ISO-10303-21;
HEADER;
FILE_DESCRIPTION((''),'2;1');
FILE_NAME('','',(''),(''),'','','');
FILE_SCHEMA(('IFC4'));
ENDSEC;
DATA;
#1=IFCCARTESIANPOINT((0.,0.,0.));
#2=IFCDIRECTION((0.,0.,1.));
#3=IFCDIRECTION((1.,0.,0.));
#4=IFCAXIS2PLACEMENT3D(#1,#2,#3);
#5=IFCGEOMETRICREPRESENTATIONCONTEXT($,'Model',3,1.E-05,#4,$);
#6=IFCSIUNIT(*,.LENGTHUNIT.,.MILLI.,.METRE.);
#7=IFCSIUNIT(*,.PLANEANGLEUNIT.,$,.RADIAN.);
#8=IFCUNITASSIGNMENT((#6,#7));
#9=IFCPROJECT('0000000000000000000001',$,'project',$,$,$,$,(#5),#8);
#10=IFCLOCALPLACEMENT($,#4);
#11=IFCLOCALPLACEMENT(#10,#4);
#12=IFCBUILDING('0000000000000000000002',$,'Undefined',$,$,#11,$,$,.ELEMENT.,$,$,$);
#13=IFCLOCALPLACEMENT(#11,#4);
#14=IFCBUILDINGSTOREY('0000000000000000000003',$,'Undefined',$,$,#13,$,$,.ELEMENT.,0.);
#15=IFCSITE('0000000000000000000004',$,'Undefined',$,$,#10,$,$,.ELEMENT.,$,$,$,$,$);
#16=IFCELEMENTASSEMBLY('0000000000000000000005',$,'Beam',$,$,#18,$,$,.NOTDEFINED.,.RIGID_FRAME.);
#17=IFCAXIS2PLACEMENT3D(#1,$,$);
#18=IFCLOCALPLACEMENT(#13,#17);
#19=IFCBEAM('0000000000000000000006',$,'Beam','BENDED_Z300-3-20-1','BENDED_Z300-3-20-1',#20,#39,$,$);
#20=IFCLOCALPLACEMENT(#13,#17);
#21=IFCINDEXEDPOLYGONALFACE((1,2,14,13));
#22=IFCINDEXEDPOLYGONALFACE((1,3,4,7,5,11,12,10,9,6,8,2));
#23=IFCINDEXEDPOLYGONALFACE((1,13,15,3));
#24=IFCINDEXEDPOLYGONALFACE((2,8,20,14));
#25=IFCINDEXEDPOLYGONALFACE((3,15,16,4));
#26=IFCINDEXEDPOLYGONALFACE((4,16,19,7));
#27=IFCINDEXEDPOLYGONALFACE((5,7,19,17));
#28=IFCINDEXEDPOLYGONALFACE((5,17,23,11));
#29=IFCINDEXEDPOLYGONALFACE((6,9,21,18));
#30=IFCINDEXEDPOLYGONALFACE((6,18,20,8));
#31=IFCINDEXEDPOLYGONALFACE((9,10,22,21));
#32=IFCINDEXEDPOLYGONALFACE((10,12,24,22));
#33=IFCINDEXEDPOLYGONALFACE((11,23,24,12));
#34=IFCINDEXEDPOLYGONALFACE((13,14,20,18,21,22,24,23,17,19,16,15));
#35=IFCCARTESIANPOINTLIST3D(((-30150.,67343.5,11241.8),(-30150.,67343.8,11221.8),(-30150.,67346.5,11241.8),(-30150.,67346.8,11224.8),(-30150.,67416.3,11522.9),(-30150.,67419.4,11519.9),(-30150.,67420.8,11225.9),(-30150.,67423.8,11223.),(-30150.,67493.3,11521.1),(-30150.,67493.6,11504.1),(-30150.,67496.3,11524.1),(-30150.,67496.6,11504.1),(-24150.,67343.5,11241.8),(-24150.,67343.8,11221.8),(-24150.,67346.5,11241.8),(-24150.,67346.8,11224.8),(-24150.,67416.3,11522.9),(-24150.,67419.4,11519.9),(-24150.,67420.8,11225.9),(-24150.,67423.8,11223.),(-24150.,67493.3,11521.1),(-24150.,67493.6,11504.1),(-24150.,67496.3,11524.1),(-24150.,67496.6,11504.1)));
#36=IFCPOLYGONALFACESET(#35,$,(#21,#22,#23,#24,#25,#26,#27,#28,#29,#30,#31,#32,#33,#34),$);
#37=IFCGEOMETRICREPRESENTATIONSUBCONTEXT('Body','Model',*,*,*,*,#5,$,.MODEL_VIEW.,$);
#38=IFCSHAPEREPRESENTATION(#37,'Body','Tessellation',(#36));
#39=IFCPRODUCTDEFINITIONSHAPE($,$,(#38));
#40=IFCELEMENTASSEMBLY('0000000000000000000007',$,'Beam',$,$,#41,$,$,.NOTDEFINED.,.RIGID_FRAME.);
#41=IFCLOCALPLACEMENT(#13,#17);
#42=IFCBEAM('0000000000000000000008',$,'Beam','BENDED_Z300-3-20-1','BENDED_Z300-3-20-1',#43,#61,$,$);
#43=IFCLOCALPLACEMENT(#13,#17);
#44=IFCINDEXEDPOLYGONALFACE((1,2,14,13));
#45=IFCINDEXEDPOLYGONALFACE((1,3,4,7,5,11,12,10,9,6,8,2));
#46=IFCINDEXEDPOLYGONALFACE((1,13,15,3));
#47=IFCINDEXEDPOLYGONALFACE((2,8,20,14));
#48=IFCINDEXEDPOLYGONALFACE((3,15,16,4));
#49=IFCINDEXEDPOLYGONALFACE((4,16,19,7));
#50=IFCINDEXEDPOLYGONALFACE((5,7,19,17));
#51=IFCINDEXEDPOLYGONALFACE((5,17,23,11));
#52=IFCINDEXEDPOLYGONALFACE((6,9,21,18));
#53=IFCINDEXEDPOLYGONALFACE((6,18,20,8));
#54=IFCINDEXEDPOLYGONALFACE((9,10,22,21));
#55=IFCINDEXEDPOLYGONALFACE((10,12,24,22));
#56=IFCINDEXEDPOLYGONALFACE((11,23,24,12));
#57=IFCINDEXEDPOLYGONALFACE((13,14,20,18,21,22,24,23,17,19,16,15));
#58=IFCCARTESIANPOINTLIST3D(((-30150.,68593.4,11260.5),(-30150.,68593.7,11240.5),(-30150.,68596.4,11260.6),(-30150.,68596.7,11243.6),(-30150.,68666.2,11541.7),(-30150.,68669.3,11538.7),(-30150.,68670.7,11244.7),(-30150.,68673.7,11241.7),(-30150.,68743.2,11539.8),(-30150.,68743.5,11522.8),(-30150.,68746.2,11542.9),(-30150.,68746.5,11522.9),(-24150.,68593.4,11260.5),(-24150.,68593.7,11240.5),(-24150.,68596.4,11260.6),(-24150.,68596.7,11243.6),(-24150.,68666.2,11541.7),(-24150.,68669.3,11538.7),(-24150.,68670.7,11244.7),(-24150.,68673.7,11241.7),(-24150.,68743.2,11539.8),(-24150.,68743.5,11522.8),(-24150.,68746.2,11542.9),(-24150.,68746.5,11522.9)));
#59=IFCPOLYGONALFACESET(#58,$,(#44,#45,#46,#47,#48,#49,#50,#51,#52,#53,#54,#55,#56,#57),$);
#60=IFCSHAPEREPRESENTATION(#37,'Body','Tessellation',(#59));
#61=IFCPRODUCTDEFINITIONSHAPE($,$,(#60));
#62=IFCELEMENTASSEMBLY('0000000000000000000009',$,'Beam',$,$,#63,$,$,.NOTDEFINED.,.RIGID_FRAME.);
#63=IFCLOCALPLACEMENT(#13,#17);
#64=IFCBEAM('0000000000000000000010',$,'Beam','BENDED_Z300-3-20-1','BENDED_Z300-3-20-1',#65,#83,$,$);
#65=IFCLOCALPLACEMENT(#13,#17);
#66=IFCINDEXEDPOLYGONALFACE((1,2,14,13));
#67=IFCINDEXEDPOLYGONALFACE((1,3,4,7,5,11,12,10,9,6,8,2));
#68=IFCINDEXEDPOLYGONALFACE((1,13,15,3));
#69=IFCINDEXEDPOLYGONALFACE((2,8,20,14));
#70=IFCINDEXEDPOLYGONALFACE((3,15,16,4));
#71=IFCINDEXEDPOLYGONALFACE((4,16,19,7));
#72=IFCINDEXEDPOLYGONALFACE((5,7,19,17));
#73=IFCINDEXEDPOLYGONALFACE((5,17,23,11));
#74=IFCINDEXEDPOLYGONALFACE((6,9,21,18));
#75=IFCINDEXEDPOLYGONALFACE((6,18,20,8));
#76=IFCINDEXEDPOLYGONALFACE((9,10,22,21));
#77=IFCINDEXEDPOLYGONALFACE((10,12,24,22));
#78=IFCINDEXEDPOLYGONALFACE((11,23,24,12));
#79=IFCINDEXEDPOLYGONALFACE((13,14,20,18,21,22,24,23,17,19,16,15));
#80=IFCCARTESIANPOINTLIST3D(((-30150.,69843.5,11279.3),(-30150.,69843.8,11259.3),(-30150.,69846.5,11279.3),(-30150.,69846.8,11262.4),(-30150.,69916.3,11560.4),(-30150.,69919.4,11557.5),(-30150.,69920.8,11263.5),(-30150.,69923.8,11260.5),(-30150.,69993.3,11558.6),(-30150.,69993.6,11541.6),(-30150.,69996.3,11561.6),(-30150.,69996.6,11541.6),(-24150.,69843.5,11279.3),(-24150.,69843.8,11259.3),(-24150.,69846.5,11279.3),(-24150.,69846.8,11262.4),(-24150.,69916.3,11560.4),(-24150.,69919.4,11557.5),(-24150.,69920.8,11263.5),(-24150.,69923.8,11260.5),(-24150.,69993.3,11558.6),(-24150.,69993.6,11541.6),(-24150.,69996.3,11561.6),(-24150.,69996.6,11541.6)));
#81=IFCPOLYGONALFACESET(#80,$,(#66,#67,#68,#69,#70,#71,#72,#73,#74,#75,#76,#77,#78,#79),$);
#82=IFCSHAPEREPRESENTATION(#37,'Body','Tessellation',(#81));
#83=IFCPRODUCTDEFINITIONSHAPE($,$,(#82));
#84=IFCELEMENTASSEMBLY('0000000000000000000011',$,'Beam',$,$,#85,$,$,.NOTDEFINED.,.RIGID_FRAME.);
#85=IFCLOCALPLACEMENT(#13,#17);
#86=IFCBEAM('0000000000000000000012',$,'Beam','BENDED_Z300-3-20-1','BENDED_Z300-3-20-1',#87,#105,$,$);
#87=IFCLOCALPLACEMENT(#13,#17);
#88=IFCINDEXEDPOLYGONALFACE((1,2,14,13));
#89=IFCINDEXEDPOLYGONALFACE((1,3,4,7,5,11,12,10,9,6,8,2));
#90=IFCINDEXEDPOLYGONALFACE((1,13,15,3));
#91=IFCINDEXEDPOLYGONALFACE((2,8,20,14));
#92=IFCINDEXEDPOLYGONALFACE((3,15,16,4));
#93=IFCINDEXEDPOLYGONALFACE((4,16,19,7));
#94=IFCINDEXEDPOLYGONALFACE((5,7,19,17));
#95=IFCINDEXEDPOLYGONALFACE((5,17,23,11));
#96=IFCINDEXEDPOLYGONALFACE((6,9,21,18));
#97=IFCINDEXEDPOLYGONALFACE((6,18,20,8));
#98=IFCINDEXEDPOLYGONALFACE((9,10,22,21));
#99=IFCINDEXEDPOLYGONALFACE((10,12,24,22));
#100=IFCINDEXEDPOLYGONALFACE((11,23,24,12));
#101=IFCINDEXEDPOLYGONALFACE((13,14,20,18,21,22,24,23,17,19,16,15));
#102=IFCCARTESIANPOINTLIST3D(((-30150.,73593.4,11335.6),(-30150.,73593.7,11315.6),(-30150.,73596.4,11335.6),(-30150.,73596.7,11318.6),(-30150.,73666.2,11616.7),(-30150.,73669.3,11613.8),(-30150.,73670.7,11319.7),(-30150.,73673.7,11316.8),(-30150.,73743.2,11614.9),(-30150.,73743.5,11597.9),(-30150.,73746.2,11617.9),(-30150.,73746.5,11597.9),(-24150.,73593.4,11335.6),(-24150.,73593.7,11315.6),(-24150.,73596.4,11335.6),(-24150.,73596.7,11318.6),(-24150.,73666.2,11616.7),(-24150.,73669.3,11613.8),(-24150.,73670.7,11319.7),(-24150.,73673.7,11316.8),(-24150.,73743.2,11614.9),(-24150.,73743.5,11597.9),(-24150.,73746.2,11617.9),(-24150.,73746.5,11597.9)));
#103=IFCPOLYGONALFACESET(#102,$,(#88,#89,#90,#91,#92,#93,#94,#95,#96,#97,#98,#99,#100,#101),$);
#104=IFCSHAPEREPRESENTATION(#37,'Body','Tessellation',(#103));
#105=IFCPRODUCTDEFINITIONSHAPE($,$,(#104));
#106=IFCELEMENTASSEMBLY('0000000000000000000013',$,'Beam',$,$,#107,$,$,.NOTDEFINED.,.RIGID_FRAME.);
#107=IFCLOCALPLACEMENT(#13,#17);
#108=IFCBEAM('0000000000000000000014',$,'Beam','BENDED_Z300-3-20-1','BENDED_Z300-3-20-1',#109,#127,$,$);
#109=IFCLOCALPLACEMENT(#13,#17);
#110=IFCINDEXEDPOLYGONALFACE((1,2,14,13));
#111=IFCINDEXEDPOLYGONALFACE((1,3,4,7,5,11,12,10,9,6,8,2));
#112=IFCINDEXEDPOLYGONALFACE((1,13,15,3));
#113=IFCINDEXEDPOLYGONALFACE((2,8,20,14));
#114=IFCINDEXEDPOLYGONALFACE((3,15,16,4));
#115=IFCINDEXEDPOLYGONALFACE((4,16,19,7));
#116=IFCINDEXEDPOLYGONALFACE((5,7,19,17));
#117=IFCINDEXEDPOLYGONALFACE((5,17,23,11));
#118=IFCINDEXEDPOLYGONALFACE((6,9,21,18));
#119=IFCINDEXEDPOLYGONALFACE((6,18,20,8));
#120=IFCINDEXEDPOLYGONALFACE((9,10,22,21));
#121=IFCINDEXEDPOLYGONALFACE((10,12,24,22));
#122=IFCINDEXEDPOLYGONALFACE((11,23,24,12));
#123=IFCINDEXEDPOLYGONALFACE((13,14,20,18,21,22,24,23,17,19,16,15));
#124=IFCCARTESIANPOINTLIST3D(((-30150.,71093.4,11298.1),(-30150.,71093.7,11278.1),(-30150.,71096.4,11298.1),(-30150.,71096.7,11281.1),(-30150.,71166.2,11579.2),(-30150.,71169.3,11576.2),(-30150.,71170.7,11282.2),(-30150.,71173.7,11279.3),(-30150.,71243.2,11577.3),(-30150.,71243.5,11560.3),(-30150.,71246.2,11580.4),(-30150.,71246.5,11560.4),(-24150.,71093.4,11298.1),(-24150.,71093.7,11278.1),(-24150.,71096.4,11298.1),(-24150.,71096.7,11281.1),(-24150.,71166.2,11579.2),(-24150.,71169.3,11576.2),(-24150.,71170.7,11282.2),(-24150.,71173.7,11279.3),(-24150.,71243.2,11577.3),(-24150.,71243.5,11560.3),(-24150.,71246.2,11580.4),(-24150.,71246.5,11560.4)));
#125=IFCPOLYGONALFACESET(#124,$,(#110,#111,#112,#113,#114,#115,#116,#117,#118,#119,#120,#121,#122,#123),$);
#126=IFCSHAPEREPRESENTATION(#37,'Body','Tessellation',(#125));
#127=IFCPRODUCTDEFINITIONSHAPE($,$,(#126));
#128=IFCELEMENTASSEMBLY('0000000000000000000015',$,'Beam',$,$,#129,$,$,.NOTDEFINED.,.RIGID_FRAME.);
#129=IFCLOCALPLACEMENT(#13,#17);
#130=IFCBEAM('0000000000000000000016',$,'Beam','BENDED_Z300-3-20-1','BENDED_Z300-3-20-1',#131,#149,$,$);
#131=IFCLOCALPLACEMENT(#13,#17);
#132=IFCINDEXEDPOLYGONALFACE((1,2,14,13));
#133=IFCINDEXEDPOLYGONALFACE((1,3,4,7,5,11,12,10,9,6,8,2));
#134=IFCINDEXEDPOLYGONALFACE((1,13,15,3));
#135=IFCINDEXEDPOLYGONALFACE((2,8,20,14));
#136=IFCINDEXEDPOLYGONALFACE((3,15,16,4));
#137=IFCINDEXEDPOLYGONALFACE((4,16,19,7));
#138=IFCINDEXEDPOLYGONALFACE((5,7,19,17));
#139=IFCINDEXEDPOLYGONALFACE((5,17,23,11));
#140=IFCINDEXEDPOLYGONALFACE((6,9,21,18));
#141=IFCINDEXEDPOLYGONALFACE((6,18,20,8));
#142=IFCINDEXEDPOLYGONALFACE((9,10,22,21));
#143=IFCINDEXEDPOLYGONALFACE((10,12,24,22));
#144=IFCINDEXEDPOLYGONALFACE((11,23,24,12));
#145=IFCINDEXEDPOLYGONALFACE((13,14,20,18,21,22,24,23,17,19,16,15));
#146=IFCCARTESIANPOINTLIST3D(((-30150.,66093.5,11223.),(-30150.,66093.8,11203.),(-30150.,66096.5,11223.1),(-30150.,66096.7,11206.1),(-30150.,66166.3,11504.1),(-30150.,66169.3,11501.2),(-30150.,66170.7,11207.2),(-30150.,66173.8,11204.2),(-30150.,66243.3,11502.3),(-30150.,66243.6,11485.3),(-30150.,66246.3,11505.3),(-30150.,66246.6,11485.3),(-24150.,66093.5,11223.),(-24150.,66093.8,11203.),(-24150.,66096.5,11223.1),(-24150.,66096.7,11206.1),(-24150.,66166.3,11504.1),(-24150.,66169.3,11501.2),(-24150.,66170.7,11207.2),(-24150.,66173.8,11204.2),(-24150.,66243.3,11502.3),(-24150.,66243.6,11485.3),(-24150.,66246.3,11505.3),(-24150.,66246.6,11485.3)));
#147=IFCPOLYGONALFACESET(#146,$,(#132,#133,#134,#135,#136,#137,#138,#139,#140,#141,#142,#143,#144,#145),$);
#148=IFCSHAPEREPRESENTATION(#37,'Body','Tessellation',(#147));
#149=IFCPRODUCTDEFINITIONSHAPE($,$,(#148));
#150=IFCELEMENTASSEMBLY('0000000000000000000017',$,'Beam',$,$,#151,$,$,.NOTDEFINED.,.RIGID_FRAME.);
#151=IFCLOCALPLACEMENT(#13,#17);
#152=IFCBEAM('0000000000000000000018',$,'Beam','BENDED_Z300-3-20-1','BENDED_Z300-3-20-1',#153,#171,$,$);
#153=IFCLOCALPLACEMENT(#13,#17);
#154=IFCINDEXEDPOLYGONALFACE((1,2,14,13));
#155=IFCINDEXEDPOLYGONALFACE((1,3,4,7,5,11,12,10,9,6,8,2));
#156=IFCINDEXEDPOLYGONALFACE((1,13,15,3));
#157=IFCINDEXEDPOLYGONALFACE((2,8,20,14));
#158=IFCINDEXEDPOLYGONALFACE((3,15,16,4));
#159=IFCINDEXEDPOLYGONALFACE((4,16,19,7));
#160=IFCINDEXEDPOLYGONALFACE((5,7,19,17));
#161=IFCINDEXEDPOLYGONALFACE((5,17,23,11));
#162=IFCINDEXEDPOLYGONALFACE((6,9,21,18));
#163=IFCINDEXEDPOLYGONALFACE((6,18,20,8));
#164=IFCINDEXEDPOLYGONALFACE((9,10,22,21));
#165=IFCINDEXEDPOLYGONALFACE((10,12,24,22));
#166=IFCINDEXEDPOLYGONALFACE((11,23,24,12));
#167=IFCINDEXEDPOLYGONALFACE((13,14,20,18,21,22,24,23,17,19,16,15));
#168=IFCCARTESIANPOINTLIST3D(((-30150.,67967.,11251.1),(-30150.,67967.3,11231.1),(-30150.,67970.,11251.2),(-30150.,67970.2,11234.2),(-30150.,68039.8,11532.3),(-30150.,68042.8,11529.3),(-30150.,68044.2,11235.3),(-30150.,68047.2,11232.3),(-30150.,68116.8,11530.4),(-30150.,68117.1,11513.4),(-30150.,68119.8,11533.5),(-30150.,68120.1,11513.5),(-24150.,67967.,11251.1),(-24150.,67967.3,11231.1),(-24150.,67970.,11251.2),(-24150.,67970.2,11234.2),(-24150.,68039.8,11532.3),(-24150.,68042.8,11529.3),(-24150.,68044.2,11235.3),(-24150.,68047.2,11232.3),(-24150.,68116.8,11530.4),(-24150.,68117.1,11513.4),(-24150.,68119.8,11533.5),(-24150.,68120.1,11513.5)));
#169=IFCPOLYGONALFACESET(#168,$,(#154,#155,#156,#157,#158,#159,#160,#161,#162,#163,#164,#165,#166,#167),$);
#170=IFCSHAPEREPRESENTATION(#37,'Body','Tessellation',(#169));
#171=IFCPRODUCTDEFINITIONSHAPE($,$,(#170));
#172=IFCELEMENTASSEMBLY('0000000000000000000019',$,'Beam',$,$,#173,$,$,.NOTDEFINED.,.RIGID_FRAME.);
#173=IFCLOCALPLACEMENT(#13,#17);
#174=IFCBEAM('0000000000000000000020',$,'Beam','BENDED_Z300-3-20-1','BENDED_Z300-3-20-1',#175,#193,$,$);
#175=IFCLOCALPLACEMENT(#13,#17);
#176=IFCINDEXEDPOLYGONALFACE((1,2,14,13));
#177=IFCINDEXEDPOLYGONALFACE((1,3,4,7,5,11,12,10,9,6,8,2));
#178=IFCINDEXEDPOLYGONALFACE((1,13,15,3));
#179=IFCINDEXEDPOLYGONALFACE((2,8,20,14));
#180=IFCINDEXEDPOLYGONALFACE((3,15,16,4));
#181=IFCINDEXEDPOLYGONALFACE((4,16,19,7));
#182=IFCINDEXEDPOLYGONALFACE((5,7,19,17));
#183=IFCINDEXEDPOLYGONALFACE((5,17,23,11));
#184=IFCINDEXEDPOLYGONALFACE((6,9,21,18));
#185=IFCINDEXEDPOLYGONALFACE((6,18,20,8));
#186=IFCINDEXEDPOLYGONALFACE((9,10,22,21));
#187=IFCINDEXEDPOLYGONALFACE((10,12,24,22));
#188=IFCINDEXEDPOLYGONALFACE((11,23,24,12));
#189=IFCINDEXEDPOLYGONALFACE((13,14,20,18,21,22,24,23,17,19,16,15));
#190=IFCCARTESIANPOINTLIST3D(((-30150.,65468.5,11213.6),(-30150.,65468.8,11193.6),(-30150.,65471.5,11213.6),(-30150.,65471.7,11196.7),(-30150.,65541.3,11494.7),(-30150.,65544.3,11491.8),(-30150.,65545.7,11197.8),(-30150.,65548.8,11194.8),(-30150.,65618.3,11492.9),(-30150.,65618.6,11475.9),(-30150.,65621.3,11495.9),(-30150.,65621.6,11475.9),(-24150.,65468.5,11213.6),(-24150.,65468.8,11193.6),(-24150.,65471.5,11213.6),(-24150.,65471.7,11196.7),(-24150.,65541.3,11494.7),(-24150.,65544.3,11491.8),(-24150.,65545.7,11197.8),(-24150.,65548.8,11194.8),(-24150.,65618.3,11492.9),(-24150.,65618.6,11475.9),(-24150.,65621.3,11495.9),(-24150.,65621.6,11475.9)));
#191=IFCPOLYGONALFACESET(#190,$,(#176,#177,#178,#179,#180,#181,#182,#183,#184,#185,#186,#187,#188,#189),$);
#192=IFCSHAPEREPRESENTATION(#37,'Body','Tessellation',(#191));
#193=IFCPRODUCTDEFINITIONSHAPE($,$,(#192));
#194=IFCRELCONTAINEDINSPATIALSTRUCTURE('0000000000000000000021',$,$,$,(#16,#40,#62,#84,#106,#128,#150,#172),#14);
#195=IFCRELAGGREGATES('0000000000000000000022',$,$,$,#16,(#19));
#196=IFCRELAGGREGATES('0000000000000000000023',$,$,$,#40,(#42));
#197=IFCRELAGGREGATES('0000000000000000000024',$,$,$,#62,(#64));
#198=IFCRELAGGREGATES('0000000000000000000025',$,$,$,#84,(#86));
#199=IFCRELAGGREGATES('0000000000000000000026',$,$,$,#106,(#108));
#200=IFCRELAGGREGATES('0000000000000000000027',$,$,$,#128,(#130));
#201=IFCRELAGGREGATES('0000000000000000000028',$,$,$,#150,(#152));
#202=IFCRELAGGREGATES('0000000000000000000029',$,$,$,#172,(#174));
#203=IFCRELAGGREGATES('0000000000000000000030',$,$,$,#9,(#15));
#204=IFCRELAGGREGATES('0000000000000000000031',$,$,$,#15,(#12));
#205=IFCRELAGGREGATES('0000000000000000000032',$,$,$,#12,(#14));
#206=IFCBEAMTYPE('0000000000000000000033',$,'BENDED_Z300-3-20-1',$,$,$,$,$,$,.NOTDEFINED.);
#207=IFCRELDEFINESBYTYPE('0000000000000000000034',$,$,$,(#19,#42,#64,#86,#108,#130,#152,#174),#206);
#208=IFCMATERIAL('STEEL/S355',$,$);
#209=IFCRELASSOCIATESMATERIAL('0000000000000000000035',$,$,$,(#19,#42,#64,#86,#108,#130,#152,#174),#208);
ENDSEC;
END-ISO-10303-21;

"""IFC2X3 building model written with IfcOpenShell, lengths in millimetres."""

from ifc_helpers import new_model, si_unit, frame, origin_with_axes, place, context, subcontext, project, spatial, polyline, outline, extrude, material, type_object, element, aggregate, save


model = new_model("IFC2X3")

# Units and contexts
model_context = context("Model", 3, precision=1e-05, world=origin_with_axes())
body_context = subcontext(model_context, "Body", "Model", "MODEL_VIEW")
ifc_project = project(units=[si_unit("LENGTHUNIT", "METRE", prefix="MILLI"), si_unit("PLANEANGLEUNIT", "RADIAN")], contexts=[model_context])

# Site, building, storey
site_placement = place(None, origin_with_axes())
site = spatial("IfcSite", under=ifc_project, at=site_placement, Name="Undefined", CompositionType="ELEMENT")
building_placement = place(site_placement, origin_with_axes())
building = spatial("IfcBuilding", under=site, at=building_placement, Name="Undefined", CompositionType="ELEMENT")
storey_placement = place(building_placement, origin_with_axes())
storey = spatial("IfcBuildingStorey", under=building, at=storey_placement, Name="Undefined", CompositionType="ELEMENT", Elevation=0.0)

# Element assemblies, beams
ifc_material_1 = material(Name="STEEL/S355")
beam_type_1 = type_object("IfcBeamType", Name="BENDED_Z300-3-20-1", PredefinedType="NOTDEFINED")
assembly_1_placement = place(storey_placement, origin_with_axes())
assembly_1 = element("IfcElementAssembly", 1, at=assembly_1_placement, inside=storey, Name="Beam", AssemblyPlace="NOTDEFINED", PredefinedType="RIGID_FRAME")
beam_1_placement = place(assembly_1_placement, frame((-24150.0, 67420.1, 11372.9), z_axis=(0.0, -0.014963, 0.999888), x_axis=(-1.0, 0.0, 0.0)))
beam_1 = element("IfcBeam", 2, at=beam_1_placement, type_object=beam_type_1, material=ifc_material_1, Name="Beam", Description="BENDED_Z300-3-20-1", ObjectType="BENDED_Z300-3-20-1", context=body_context, shape_type="SweptSolid", body=[
    extrude(outline(polyline([(1.5, -150.0), (-78.5, -150.0), (-78.5, -130.0), (-75.5, -130.0), (-75.5, -147.0), (-1.5, -147.0), (-1.5, 150.0), (78.5, 150.0), (78.5, 130.0), (75.5, 130.0), (75.5, 147.0), (1.5, 147.0), (1.5, -150.0)])), frame((6000.0, 0.0, 0.0), z_axis=(-1.0, 0.0, 0.0), x_axis=(0.0, -1.0, 0.0)), (0.0, 0.0, 1.0), 6000.0),
])
aggregate(assembly_1, [beam_1])
assembly_2_placement = place(storey_placement, origin_with_axes())
assembly_2 = element("IfcElementAssembly", 3, at=assembly_2_placement, inside=storey, Name="Beam", AssemblyPlace="NOTDEFINED", PredefinedType="RIGID_FRAME")
beam_2_placement = place(assembly_2_placement, frame((-24150.0, 68670.0, 11391.7), z_axis=(0.0, -0.014963, 0.999888), x_axis=(-1.0, 0.0, 0.0)))
beam_2 = element("IfcBeam", 4, at=beam_2_placement, type_object=beam_type_1, material=ifc_material_1, Name="Beam", Description="BENDED_Z300-3-20-1", ObjectType="BENDED_Z300-3-20-1", context=body_context, shape_type="SweptSolid", body=[
    extrude(outline(polyline([(1.5, -150.0), (-78.5, -150.0), (-78.5, -130.0), (-75.5, -130.0), (-75.5, -147.0), (-1.5, -147.0), (-1.5, 150.0), (78.5, 150.0), (78.5, 130.0), (75.5, 130.0), (75.5, 147.0), (1.5, 147.0), (1.5, -150.0)])), frame((6000.0, 0.0, 0.0), z_axis=(-1.0, 0.0, 0.0), x_axis=(0.0, -1.0, 0.0)), (0.0, 0.0, 1.0), 6000.0),
])
aggregate(assembly_2, [beam_2])
assembly_3_placement = place(storey_placement, origin_with_axes())
assembly_3 = element("IfcElementAssembly", 5, at=assembly_3_placement, inside=storey, Name="Beam", AssemblyPlace="NOTDEFINED", PredefinedType="RIGID_FRAME")
beam_3_placement = place(assembly_3_placement, frame((-24150.0, 69920.1, 11410.5), z_axis=(0.0, -0.014963, 0.999888), x_axis=(-1.0, 0.0, 0.0)))
beam_3 = element("IfcBeam", 6, at=beam_3_placement, type_object=beam_type_1, material=ifc_material_1, Name="Beam", Description="BENDED_Z300-3-20-1", ObjectType="BENDED_Z300-3-20-1", context=body_context, shape_type="SweptSolid", body=[
    extrude(outline(polyline([(1.5, -150.0), (-78.5, -150.0), (-78.5, -130.0), (-75.5, -130.0), (-75.5, -147.0), (-1.5, -147.0), (-1.5, 150.0), (78.5, 150.0), (78.5, 130.0), (75.5, 130.0), (75.5, 147.0), (1.5, 147.0), (1.5, -150.0)])), frame((6000.0, 0.0, 0.0), z_axis=(-1.0, 0.0, 0.0), x_axis=(0.0, -1.0, 0.0)), (0.0, 0.0, 1.0), 6000.0),
])
aggregate(assembly_3, [beam_3])
assembly_4_placement = place(storey_placement, origin_with_axes())
assembly_4 = element("IfcElementAssembly", 7, at=assembly_4_placement, inside=storey, Name="Beam", AssemblyPlace="NOTDEFINED", PredefinedType="RIGID_FRAME")
beam_4_placement = place(assembly_4_placement, frame((-24150.0, 73670.0, 11466.8), z_axis=(0.0, -0.014963, 0.999888), x_axis=(-1.0, 0.0, 0.0)))
beam_4 = element("IfcBeam", 8, at=beam_4_placement, type_object=beam_type_1, material=ifc_material_1, Name="Beam", Description="BENDED_Z300-3-20-1", ObjectType="BENDED_Z300-3-20-1", context=body_context, shape_type="SweptSolid", body=[
    extrude(outline(polyline([(1.5, -150.0), (-78.5, -150.0), (-78.5, -130.0), (-75.5, -130.0), (-75.5, -147.0), (-1.5, -147.0), (-1.5, 150.0), (78.5, 150.0), (78.5, 130.0), (75.5, 130.0), (75.5, 147.0), (1.5, 147.0), (1.5, -150.0)])), frame((6000.0, 0.0, 0.0), z_axis=(-1.0, 0.0, 0.0), x_axis=(0.0, -1.0, 0.0)), (0.0, 0.0, 1.0), 6000.0),
])
aggregate(assembly_4, [beam_4])
assembly_5_placement = place(storey_placement, origin_with_axes())
assembly_5 = element("IfcElementAssembly", 9, at=assembly_5_placement, inside=storey, Name="Beam", AssemblyPlace="NOTDEFINED", PredefinedType="RIGID_FRAME")
beam_5_placement = place(assembly_5_placement, frame((-24150.0, 71170.0, 11429.2), z_axis=(0.0, -0.014963, 0.999888), x_axis=(-1.0, 0.0, 0.0)))
beam_5 = element("IfcBeam", 10, at=beam_5_placement, type_object=beam_type_1, material=ifc_material_1, Name="Beam", Description="BENDED_Z300-3-20-1", ObjectType="BENDED_Z300-3-20-1", context=body_context, shape_type="SweptSolid", body=[
    extrude(outline(polyline([(1.5, -150.0), (-78.5, -150.0), (-78.5, -130.0), (-75.5, -130.0), (-75.5, -147.0), (-1.5, -147.0), (-1.5, 150.0), (78.5, 150.0), (78.5, 130.0), (75.5, 130.0), (75.5, 147.0), (1.5, 147.0), (1.5, -150.0)])), frame((6000.0, 0.0, 0.0), z_axis=(-1.0, 0.0, 0.0), x_axis=(0.0, -1.0, 0.0)), (0.0, 0.0, 1.0), 6000.0),
])
aggregate(assembly_5, [beam_5])
assembly_6_placement = place(storey_placement, origin_with_axes())
assembly_6 = element("IfcElementAssembly", 11, at=assembly_6_placement, inside=storey, Name="Beam", AssemblyPlace="NOTDEFINED", PredefinedType="RIGID_FRAME")
beam_6_placement = place(assembly_6_placement, frame((-24150.0, 66170.0, 11354.2), z_axis=(0.0, -0.014963, 0.999888), x_axis=(-1.0, 0.0, 0.0)))
beam_6 = element("IfcBeam", 12, at=beam_6_placement, type_object=beam_type_1, material=ifc_material_1, Name="Beam", Description="BENDED_Z300-3-20-1", ObjectType="BENDED_Z300-3-20-1", context=body_context, shape_type="SweptSolid", body=[
    extrude(outline(polyline([(1.5, -150.0), (-78.5, -150.0), (-78.5, -130.0), (-75.5, -130.0), (-75.5, -147.0), (-1.5, -147.0), (-1.5, 150.0), (78.5, 150.0), (78.5, 130.0), (75.5, 130.0), (75.5, 147.0), (1.5, 147.0), (1.5, -150.0)])), frame((6000.0, 0.0, 0.0), z_axis=(-1.0, 0.0, 0.0), x_axis=(0.0, -1.0, 0.0)), (0.0, 0.0, 1.0), 6000.0),
])
aggregate(assembly_6, [beam_6])
assembly_7_placement = place(storey_placement, origin_with_axes())
assembly_7 = element("IfcElementAssembly", 13, at=assembly_7_placement, inside=storey, Name="Beam", AssemblyPlace="NOTDEFINED", PredefinedType="RIGID_FRAME")
beam_7_placement = place(assembly_7_placement, frame((-24150.0, 68043.5, 11382.3), z_axis=(0.0, -0.014963, 0.999888), x_axis=(-1.0, 0.0, 0.0)))
beam_7 = element("IfcBeam", 14, at=beam_7_placement, type_object=beam_type_1, material=ifc_material_1, Name="Beam", Description="BENDED_Z300-3-20-1", ObjectType="BENDED_Z300-3-20-1", context=body_context, shape_type="SweptSolid", body=[
    extrude(outline(polyline([(1.5, -150.0), (-78.5, -150.0), (-78.5, -130.0), (-75.5, -130.0), (-75.5, -147.0), (-1.5, -147.0), (-1.5, 150.0), (78.5, 150.0), (78.5, 130.0), (75.5, 130.0), (75.5, 147.0), (1.5, 147.0), (1.5, -150.0)])), frame((6000.0, 0.0, 0.0), z_axis=(-1.0, 0.0, 0.0), x_axis=(0.0, -1.0, 0.0)), (0.0, 0.0, 1.0), 6000.0),
])
aggregate(assembly_7, [beam_7])
assembly_8_placement = place(storey_placement, origin_with_axes())
assembly_8 = element("IfcElementAssembly", 15, at=assembly_8_placement, inside=storey, Name="Beam", AssemblyPlace="NOTDEFINED", PredefinedType="RIGID_FRAME")
beam_8_placement = place(assembly_8_placement, frame((-24150.0, 65545.0, 11344.8), z_axis=(0.0, -0.014963, 0.999888), x_axis=(-1.0, 0.0, 0.0)))
beam_8 = element("IfcBeam", 16, at=beam_8_placement, type_object=beam_type_1, material=ifc_material_1, Name="Beam", Description="BENDED_Z300-3-20-1", ObjectType="BENDED_Z300-3-20-1", context=body_context, shape_type="SweptSolid", body=[
    extrude(outline(polyline([(1.5, -150.0), (-78.5, -150.0), (-78.5, -130.0), (-75.5, -130.0), (-75.5, -147.0), (-1.5, -147.0), (-1.5, 150.0), (78.5, 150.0), (78.5, 130.0), (75.5, 130.0), (75.5, 147.0), (1.5, 147.0), (1.5, -150.0)])), frame((6000.0, 0.0, 0.0), z_axis=(-1.0, 0.0, 0.0), x_axis=(0.0, -1.0, 0.0)), (0.0, 0.0, 1.0), 6000.0),
])
aggregate(assembly_8, [beam_8])

save(model, "model.ifc")
